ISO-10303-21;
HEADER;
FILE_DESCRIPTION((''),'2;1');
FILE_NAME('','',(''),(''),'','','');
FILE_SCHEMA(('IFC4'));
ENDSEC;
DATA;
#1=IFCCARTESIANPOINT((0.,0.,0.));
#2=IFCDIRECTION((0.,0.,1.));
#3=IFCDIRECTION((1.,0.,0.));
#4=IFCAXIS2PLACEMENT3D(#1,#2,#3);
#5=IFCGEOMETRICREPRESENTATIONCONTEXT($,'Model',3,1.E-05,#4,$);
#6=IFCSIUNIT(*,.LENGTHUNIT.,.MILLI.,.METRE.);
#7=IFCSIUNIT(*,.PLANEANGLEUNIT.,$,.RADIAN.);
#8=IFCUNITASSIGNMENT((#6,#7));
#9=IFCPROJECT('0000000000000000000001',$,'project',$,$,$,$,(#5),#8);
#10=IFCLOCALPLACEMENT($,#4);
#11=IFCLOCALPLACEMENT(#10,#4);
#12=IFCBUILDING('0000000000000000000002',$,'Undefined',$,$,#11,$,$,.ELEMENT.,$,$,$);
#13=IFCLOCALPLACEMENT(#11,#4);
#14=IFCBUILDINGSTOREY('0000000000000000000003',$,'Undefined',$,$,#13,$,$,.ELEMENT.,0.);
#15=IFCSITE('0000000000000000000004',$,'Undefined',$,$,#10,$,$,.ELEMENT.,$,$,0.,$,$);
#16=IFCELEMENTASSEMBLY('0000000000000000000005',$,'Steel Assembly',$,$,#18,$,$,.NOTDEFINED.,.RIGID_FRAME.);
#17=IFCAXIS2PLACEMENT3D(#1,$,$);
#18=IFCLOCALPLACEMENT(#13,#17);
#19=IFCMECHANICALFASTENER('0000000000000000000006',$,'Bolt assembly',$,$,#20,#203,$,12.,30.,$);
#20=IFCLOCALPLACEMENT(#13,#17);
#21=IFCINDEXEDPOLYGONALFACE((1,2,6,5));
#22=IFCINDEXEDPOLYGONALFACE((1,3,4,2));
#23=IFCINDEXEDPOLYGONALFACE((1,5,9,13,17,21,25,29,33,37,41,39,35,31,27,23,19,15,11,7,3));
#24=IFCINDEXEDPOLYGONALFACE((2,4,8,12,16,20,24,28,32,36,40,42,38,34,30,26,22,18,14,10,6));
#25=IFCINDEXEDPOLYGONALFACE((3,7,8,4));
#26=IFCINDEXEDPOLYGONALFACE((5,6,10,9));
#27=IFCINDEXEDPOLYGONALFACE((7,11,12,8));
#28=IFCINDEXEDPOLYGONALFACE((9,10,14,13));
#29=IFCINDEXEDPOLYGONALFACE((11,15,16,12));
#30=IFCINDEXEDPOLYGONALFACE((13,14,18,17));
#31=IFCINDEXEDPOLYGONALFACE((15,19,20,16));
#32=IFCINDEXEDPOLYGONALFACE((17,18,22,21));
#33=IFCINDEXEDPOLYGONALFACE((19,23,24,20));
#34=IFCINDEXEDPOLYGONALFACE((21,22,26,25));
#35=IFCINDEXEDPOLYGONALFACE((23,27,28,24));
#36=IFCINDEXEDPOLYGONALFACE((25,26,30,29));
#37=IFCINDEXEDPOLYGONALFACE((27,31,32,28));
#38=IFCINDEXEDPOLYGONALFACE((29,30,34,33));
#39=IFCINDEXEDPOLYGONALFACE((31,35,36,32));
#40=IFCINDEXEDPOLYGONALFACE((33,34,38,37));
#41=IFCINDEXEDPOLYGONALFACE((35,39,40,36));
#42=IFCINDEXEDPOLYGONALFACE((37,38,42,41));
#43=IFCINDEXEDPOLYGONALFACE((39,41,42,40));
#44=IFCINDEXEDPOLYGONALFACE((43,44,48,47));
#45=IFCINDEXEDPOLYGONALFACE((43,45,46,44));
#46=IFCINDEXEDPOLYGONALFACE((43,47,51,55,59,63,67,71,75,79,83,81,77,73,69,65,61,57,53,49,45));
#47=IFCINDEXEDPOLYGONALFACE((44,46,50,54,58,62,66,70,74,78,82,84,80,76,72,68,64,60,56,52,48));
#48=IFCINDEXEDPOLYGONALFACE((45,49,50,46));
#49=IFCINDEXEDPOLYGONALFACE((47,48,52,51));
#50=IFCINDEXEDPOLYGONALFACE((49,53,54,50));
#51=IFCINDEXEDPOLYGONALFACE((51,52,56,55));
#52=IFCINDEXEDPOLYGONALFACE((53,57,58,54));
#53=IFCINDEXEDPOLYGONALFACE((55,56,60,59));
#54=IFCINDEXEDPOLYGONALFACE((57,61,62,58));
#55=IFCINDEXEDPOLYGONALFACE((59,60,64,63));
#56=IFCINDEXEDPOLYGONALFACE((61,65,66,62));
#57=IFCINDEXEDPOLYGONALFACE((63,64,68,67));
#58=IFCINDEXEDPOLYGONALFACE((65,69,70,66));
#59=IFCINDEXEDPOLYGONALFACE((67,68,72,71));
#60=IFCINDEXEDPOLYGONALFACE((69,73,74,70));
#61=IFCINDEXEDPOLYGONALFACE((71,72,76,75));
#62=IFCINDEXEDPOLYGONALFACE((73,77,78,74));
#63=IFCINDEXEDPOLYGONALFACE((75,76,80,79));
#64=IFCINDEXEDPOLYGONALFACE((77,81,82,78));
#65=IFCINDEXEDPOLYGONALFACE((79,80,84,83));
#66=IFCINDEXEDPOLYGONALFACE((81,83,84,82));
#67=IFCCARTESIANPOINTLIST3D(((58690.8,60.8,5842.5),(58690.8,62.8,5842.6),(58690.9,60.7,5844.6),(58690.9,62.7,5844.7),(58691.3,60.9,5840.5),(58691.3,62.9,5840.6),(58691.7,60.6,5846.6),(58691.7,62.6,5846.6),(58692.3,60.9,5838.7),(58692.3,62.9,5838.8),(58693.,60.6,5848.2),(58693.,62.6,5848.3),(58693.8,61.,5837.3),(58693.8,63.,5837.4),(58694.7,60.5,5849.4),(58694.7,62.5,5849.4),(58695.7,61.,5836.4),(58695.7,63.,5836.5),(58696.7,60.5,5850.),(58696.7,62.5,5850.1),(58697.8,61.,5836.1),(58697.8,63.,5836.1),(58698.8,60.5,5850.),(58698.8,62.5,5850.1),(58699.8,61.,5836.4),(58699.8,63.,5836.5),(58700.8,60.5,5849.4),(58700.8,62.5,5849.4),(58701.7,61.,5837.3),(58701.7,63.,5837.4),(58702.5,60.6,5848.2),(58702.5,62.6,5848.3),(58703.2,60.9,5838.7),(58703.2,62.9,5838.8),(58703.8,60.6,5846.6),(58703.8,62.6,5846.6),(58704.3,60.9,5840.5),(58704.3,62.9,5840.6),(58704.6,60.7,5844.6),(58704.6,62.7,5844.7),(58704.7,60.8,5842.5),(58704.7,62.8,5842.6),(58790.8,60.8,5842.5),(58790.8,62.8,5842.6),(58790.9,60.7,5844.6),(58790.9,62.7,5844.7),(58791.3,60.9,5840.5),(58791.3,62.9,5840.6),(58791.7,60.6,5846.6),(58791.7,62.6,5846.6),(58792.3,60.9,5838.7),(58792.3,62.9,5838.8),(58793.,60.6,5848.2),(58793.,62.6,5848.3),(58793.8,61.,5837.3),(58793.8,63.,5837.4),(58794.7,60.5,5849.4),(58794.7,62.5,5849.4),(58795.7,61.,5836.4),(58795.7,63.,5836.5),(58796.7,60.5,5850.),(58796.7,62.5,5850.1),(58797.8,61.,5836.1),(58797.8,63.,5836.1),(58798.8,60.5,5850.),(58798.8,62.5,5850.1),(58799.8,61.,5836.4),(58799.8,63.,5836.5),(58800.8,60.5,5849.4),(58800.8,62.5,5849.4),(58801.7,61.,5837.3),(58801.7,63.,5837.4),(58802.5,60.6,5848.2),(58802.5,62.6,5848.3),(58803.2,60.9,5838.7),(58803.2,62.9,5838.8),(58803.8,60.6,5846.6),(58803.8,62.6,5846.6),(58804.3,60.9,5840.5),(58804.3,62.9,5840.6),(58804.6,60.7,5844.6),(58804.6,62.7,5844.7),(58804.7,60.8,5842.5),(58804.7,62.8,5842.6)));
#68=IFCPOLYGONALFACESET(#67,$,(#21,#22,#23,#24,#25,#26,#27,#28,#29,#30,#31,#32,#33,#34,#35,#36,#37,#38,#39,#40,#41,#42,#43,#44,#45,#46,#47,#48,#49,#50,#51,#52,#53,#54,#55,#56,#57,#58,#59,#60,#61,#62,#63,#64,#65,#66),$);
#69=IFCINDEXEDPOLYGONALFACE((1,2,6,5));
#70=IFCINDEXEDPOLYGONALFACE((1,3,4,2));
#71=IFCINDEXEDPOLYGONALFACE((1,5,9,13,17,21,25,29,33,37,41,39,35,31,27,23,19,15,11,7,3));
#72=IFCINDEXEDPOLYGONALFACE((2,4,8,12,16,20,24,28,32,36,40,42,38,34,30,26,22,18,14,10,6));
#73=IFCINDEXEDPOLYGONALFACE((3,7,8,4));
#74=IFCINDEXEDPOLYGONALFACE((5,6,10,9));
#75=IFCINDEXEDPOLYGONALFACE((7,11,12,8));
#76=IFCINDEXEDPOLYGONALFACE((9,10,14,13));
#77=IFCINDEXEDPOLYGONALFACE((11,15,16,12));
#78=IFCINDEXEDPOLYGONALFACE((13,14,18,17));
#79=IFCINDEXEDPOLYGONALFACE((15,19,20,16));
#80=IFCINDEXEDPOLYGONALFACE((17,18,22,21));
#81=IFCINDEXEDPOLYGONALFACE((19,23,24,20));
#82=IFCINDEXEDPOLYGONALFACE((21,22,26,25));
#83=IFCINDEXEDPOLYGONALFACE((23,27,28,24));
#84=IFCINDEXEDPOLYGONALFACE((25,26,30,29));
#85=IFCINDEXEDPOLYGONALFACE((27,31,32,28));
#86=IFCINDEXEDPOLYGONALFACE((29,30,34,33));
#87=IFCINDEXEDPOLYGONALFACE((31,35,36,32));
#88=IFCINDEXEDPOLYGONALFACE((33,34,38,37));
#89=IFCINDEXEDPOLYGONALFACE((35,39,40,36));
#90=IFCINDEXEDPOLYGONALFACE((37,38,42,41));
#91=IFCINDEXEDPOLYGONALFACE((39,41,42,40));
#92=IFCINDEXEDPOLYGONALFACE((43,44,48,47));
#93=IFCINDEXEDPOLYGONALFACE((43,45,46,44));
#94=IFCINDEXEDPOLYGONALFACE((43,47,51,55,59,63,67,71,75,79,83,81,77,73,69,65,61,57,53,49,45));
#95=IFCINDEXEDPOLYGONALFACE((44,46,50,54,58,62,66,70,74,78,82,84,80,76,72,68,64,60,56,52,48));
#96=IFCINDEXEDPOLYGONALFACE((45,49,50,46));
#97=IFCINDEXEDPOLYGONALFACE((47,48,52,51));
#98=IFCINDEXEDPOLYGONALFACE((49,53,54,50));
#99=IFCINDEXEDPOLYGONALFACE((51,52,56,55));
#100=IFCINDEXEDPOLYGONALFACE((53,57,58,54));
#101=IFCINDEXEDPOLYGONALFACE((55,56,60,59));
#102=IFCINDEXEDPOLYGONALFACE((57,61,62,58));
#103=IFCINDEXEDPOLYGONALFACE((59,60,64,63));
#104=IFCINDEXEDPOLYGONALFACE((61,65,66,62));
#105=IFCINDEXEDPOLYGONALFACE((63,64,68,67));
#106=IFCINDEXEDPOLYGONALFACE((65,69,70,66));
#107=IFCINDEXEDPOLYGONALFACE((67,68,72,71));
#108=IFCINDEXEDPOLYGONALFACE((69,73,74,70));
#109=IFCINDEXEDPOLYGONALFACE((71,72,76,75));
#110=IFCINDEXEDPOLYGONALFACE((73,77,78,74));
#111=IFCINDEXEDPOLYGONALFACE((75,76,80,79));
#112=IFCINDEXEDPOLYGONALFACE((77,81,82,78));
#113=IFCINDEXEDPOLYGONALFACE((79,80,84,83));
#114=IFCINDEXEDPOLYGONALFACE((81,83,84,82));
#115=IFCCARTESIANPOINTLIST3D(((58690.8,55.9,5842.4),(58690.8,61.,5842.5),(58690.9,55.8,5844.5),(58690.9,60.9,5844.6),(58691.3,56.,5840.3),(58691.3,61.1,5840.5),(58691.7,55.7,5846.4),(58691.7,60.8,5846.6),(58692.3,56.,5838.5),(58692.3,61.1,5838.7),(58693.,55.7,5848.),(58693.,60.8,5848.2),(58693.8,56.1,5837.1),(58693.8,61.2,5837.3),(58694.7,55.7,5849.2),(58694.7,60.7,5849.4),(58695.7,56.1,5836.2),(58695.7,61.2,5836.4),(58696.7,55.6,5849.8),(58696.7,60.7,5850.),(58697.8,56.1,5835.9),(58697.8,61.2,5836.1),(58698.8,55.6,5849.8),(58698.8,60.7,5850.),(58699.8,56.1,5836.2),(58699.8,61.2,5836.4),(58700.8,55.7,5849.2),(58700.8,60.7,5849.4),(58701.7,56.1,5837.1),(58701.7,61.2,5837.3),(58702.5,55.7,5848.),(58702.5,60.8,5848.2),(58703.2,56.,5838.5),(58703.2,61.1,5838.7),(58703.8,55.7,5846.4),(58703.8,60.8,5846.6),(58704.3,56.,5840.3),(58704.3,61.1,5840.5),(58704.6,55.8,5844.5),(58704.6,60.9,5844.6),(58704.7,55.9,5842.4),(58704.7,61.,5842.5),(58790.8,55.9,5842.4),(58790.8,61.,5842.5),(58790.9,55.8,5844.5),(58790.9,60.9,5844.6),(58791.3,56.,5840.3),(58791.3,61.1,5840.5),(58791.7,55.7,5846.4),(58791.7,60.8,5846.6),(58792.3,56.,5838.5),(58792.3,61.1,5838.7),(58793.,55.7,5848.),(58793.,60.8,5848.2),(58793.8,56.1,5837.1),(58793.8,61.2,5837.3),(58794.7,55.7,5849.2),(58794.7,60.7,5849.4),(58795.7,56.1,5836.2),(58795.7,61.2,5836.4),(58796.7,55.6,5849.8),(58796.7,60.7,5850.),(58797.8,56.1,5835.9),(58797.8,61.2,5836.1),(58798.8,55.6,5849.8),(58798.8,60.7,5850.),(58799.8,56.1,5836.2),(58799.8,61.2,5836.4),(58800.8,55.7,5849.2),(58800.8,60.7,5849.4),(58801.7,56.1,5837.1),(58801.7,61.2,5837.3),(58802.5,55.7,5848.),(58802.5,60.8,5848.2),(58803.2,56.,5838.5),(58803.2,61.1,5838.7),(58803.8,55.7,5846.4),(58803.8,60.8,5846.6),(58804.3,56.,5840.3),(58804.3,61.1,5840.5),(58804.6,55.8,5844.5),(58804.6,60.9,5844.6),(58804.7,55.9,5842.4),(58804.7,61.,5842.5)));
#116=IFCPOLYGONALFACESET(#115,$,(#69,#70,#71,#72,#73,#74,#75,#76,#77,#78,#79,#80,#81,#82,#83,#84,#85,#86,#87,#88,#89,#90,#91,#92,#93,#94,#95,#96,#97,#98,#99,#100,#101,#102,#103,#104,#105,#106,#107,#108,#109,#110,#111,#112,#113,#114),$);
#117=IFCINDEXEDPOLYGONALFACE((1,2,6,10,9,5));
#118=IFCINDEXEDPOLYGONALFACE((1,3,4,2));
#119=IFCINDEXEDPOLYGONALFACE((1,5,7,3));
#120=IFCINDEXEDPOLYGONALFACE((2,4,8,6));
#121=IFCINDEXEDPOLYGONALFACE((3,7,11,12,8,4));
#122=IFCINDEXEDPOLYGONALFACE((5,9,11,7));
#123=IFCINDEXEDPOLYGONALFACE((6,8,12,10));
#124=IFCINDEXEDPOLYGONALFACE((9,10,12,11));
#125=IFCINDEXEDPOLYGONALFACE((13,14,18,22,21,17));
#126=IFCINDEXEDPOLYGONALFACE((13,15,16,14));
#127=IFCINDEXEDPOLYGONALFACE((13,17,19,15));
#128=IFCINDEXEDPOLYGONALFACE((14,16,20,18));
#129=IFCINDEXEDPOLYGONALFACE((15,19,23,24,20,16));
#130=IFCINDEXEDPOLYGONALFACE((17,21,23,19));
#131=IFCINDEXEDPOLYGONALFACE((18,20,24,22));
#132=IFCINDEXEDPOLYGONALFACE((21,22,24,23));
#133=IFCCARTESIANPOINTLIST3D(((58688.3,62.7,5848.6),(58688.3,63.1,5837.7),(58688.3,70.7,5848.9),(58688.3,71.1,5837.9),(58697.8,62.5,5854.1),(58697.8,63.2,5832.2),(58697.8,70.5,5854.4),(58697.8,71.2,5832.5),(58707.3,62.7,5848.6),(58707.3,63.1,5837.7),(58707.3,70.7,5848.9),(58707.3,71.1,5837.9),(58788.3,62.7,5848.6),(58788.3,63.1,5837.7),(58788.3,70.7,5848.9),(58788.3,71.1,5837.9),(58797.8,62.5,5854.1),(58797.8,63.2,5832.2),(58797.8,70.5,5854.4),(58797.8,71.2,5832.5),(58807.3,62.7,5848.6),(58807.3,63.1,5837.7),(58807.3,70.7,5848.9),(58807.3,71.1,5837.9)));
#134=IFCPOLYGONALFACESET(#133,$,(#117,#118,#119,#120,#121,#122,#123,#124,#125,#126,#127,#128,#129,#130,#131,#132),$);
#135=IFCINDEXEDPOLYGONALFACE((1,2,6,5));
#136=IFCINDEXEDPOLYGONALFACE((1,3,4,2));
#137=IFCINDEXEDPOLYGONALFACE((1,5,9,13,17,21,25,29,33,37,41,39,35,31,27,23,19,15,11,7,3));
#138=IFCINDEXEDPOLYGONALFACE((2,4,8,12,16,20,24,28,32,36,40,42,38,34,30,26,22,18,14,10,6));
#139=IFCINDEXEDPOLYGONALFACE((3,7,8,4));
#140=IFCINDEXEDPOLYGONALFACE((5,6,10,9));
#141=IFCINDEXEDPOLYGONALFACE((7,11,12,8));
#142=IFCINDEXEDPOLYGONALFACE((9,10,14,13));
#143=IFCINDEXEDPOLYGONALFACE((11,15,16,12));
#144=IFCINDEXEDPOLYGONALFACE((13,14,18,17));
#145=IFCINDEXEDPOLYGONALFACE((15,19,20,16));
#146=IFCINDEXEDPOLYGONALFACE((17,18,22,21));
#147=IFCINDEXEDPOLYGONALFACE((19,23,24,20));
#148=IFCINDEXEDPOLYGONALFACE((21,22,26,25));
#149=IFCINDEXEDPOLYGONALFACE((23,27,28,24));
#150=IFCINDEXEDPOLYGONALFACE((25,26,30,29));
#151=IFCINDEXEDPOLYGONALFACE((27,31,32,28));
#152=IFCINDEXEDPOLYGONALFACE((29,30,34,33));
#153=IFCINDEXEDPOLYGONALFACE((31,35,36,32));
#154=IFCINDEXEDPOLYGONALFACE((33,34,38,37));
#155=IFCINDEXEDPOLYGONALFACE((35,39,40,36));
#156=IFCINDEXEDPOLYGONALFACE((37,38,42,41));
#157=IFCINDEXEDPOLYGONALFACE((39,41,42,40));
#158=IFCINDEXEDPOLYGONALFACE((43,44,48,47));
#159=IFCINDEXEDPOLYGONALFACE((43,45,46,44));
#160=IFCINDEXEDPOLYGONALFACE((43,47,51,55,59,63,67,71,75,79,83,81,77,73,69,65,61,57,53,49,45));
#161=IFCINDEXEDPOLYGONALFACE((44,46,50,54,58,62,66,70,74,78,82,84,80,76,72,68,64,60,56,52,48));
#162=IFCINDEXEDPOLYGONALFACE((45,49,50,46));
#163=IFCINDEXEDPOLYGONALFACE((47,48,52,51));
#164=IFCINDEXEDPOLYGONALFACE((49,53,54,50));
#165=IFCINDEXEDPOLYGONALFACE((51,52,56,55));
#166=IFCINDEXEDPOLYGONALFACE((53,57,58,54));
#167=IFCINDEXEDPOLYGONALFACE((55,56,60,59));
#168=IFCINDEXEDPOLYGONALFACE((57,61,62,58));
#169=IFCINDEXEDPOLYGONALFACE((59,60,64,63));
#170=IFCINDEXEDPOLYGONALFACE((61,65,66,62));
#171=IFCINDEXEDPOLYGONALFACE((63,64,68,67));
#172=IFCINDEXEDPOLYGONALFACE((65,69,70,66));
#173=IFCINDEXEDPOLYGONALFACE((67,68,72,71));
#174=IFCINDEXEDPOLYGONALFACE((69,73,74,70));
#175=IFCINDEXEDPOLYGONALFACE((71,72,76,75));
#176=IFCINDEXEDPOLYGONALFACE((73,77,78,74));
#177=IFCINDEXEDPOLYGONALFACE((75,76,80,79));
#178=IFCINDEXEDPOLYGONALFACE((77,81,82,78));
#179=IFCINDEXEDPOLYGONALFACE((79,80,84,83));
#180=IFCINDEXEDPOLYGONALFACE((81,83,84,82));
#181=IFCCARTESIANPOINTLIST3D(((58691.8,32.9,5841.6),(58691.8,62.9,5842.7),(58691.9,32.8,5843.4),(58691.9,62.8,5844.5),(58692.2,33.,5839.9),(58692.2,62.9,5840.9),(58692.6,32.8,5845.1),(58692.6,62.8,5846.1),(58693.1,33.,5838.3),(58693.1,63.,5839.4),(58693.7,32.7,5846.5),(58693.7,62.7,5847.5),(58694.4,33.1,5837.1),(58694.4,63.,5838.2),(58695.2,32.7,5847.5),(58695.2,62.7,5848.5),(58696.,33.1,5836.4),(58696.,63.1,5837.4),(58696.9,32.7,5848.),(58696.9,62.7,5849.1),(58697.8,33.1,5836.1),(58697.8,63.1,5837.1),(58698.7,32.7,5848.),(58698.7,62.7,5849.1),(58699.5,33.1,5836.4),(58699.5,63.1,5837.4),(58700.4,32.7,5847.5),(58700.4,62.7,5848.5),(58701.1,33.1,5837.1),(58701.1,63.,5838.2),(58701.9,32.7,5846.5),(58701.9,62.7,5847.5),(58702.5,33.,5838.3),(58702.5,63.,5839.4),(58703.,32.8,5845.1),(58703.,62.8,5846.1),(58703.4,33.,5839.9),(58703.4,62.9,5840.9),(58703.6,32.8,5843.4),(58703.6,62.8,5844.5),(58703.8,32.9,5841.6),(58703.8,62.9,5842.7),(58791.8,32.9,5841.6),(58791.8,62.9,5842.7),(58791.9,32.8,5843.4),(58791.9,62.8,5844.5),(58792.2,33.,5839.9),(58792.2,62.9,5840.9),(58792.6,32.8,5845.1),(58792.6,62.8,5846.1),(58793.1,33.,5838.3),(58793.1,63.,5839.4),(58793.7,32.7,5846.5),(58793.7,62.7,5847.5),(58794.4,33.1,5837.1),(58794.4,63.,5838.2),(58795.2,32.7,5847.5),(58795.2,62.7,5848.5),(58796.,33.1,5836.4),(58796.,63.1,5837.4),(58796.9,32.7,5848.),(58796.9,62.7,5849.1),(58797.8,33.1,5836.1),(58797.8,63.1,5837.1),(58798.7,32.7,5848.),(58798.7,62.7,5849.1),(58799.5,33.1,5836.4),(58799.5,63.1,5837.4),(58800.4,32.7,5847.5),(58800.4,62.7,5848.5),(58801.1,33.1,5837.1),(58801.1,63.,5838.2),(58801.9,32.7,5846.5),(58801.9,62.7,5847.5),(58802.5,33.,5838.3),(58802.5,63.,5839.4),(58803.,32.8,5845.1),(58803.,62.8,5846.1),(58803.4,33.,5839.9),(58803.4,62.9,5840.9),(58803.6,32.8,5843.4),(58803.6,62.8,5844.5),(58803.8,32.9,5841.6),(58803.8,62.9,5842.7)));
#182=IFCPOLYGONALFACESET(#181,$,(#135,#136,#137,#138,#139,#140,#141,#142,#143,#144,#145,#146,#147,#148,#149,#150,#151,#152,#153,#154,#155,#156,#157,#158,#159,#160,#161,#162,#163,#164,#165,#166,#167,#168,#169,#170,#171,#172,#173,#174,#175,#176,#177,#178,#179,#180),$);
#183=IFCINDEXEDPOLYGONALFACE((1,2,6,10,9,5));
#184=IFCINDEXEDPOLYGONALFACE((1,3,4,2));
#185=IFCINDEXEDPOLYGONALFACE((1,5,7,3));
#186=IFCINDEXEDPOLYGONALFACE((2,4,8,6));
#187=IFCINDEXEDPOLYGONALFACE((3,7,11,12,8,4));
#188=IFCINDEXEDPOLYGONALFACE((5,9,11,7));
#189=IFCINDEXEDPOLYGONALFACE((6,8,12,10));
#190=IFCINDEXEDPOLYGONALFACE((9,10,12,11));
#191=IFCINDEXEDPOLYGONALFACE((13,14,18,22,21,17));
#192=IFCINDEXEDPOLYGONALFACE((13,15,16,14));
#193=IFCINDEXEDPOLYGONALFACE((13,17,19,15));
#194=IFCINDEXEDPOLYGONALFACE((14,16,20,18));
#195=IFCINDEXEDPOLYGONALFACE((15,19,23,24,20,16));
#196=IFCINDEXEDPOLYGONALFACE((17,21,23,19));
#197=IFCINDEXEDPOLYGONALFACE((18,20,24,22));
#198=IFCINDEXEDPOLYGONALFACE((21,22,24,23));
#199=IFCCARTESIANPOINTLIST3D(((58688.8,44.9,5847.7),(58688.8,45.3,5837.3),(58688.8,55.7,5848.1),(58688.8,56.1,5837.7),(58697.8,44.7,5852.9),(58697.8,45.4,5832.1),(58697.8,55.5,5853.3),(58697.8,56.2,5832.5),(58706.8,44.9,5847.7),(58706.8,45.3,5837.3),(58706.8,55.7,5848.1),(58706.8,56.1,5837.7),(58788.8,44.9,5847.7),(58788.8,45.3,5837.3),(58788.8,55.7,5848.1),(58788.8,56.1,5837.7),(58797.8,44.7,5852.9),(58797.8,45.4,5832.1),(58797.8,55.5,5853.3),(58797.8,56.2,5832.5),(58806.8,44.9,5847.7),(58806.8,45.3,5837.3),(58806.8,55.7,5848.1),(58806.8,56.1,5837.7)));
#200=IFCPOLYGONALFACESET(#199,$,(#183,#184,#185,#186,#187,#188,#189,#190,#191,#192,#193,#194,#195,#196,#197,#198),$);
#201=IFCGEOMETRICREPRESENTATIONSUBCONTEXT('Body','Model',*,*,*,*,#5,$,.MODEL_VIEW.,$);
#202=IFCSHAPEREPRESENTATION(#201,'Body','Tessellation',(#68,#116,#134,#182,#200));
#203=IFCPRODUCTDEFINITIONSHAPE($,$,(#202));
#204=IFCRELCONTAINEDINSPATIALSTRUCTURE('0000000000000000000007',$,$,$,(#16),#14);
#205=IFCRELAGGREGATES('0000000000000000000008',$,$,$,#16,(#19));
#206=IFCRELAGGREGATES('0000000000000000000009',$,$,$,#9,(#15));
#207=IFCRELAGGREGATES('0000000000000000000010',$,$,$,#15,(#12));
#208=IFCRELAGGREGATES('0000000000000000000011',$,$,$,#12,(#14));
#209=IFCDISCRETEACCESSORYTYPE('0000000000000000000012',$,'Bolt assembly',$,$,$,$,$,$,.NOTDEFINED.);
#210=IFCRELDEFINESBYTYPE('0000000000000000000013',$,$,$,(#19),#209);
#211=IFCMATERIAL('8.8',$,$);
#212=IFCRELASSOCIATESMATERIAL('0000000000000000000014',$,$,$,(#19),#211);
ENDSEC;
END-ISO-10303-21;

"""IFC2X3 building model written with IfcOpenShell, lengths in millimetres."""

from ifc_helpers import new_model, si_unit, frame, origin_with_axes, origin_2d_with_axis, place, context, subcontext, project, spatial, polyline, circle, outline, extrude, source, transform, mapped, material, type_object, element, aggregate, save


model = new_model("IFC2X3")

# Units and contexts
model_context = context("Model", 3, precision=1e-05, world=origin_with_axes())
body_context = subcontext(model_context, "Body", "Model", "MODEL_VIEW")
ifc_project = project(units=[si_unit("LENGTHUNIT", "METRE", prefix="MILLI"), si_unit("PLANEANGLEUNIT", "RADIAN")], contexts=[model_context])

# Site, building, storey
site_placement = place(None, origin_with_axes())
site = spatial("IfcSite", under=ifc_project, at=site_placement, Name="Undefined", CompositionType="ELEMENT", RefElevation=0.0)
building_placement = place(site_placement, origin_with_axes())
building = spatial("IfcBuilding", under=site, at=building_placement, Name="Undefined", CompositionType="ELEMENT")
storey_placement = place(building_placement, origin_with_axes())
storey = spatial("IfcBuildingStorey", under=building, at=storey_placement, Name="Undefined", CompositionType="ELEMENT", Elevation=0.0)

# Shared definitions
discrete_accessory_type_1 = type_object("IfcDiscreteAccessoryType", Name="Bolt assembly")

# Shared definitions
ifc_material_1 = material(Name="8.8")

# Element assembly, mechanical fastener
assembly_1_placement = place(storey_placement, origin_with_axes())
assembly_1 = element("IfcElementAssembly", 1, at=assembly_1_placement, inside=storey, Name="Steel Assembly", AssemblyPlace="NOTDEFINED", PredefinedType="RIGID_FRAME")
shared_shape_1 = source(origin_with_axes(), body_context, "Body", "SweptSolid", [
    extrude(circle(Radius=7.0, at=origin_2d_with_axis()), frame((0.0, -1.9, 0.0), z_axis=(0.0, 1.0, 0.0), x_axis=(1.0, 0.0, 0.0)), (0.0, 0.0, 1.0), 2.0),
    extrude(circle(Radius=7.0, at=origin_2d_with_axis()), frame((0.0, -0.1, 0.0), z_axis=(0.0, 1.0, 0.0), x_axis=(1.0, 0.0, 0.0)), (0.0, 0.0, 1.0), 5.1),
    extrude(outline(polyline([(11.0, 0.0), (5.5, 9.5), (-5.5, 9.5), (-11.0, 0.0), (-5.5, -9.5), (5.5, -9.5), (11.0, 0.0)])), frame((0.0, -10.0, 0.0), z_axis=(0.0, 1.0, 0.0), x_axis=(1.0, 0.0, 0.0)), (0.0, 0.0, 1.0), 8.0),
    extrude(circle(Radius=6.0, at=origin_2d_with_axis()), frame((0.0, -2.0, 0.0), z_axis=(0.0, 1.0, 0.0), x_axis=(1.0, 0.0, 0.0)), (0.0, 0.0, 1.0), 30.0),
    extrude(outline(polyline([(10.4, 0.0), (5.2, 9.0), (-5.2, 9.0), (-10.4, 0.0), (-5.2, -9.0), (5.2, -9.0), (10.4, 0.0)])), frame((0.0, 5.0, 0.0), z_axis=(0.0, 1.0, 0.0), x_axis=(1.0, 0.0, 0.0)), (0.0, 0.0, 1.0), 10.8),
])
mechanical_fastener_1_placement = place(assembly_1_placement, frame((58747.8, 60.9, 5843.1), z_axis=(-1.0, 0.0, 0.0), x_axis=(0.0, 0.035062, -0.999385)))
mechanical_fastener_1 = element("IfcMechanicalFastener", 2, at=mechanical_fastener_1_placement, type_object=discrete_accessory_type_1, material=ifc_material_1, Name="Bolt assembly", NominalDiameter=12.0, NominalLength=30.0, context=body_context, shape_type="MappedRepresentation", body=[
    mapped(shared_shape_1, transform((0.0, 0.0, 50.0))),
    mapped(shared_shape_1, transform((0.0, 0.0, -50.0))),
])
aggregate(assembly_1, [mechanical_fastener_1])

save(model, "model.ifc")
